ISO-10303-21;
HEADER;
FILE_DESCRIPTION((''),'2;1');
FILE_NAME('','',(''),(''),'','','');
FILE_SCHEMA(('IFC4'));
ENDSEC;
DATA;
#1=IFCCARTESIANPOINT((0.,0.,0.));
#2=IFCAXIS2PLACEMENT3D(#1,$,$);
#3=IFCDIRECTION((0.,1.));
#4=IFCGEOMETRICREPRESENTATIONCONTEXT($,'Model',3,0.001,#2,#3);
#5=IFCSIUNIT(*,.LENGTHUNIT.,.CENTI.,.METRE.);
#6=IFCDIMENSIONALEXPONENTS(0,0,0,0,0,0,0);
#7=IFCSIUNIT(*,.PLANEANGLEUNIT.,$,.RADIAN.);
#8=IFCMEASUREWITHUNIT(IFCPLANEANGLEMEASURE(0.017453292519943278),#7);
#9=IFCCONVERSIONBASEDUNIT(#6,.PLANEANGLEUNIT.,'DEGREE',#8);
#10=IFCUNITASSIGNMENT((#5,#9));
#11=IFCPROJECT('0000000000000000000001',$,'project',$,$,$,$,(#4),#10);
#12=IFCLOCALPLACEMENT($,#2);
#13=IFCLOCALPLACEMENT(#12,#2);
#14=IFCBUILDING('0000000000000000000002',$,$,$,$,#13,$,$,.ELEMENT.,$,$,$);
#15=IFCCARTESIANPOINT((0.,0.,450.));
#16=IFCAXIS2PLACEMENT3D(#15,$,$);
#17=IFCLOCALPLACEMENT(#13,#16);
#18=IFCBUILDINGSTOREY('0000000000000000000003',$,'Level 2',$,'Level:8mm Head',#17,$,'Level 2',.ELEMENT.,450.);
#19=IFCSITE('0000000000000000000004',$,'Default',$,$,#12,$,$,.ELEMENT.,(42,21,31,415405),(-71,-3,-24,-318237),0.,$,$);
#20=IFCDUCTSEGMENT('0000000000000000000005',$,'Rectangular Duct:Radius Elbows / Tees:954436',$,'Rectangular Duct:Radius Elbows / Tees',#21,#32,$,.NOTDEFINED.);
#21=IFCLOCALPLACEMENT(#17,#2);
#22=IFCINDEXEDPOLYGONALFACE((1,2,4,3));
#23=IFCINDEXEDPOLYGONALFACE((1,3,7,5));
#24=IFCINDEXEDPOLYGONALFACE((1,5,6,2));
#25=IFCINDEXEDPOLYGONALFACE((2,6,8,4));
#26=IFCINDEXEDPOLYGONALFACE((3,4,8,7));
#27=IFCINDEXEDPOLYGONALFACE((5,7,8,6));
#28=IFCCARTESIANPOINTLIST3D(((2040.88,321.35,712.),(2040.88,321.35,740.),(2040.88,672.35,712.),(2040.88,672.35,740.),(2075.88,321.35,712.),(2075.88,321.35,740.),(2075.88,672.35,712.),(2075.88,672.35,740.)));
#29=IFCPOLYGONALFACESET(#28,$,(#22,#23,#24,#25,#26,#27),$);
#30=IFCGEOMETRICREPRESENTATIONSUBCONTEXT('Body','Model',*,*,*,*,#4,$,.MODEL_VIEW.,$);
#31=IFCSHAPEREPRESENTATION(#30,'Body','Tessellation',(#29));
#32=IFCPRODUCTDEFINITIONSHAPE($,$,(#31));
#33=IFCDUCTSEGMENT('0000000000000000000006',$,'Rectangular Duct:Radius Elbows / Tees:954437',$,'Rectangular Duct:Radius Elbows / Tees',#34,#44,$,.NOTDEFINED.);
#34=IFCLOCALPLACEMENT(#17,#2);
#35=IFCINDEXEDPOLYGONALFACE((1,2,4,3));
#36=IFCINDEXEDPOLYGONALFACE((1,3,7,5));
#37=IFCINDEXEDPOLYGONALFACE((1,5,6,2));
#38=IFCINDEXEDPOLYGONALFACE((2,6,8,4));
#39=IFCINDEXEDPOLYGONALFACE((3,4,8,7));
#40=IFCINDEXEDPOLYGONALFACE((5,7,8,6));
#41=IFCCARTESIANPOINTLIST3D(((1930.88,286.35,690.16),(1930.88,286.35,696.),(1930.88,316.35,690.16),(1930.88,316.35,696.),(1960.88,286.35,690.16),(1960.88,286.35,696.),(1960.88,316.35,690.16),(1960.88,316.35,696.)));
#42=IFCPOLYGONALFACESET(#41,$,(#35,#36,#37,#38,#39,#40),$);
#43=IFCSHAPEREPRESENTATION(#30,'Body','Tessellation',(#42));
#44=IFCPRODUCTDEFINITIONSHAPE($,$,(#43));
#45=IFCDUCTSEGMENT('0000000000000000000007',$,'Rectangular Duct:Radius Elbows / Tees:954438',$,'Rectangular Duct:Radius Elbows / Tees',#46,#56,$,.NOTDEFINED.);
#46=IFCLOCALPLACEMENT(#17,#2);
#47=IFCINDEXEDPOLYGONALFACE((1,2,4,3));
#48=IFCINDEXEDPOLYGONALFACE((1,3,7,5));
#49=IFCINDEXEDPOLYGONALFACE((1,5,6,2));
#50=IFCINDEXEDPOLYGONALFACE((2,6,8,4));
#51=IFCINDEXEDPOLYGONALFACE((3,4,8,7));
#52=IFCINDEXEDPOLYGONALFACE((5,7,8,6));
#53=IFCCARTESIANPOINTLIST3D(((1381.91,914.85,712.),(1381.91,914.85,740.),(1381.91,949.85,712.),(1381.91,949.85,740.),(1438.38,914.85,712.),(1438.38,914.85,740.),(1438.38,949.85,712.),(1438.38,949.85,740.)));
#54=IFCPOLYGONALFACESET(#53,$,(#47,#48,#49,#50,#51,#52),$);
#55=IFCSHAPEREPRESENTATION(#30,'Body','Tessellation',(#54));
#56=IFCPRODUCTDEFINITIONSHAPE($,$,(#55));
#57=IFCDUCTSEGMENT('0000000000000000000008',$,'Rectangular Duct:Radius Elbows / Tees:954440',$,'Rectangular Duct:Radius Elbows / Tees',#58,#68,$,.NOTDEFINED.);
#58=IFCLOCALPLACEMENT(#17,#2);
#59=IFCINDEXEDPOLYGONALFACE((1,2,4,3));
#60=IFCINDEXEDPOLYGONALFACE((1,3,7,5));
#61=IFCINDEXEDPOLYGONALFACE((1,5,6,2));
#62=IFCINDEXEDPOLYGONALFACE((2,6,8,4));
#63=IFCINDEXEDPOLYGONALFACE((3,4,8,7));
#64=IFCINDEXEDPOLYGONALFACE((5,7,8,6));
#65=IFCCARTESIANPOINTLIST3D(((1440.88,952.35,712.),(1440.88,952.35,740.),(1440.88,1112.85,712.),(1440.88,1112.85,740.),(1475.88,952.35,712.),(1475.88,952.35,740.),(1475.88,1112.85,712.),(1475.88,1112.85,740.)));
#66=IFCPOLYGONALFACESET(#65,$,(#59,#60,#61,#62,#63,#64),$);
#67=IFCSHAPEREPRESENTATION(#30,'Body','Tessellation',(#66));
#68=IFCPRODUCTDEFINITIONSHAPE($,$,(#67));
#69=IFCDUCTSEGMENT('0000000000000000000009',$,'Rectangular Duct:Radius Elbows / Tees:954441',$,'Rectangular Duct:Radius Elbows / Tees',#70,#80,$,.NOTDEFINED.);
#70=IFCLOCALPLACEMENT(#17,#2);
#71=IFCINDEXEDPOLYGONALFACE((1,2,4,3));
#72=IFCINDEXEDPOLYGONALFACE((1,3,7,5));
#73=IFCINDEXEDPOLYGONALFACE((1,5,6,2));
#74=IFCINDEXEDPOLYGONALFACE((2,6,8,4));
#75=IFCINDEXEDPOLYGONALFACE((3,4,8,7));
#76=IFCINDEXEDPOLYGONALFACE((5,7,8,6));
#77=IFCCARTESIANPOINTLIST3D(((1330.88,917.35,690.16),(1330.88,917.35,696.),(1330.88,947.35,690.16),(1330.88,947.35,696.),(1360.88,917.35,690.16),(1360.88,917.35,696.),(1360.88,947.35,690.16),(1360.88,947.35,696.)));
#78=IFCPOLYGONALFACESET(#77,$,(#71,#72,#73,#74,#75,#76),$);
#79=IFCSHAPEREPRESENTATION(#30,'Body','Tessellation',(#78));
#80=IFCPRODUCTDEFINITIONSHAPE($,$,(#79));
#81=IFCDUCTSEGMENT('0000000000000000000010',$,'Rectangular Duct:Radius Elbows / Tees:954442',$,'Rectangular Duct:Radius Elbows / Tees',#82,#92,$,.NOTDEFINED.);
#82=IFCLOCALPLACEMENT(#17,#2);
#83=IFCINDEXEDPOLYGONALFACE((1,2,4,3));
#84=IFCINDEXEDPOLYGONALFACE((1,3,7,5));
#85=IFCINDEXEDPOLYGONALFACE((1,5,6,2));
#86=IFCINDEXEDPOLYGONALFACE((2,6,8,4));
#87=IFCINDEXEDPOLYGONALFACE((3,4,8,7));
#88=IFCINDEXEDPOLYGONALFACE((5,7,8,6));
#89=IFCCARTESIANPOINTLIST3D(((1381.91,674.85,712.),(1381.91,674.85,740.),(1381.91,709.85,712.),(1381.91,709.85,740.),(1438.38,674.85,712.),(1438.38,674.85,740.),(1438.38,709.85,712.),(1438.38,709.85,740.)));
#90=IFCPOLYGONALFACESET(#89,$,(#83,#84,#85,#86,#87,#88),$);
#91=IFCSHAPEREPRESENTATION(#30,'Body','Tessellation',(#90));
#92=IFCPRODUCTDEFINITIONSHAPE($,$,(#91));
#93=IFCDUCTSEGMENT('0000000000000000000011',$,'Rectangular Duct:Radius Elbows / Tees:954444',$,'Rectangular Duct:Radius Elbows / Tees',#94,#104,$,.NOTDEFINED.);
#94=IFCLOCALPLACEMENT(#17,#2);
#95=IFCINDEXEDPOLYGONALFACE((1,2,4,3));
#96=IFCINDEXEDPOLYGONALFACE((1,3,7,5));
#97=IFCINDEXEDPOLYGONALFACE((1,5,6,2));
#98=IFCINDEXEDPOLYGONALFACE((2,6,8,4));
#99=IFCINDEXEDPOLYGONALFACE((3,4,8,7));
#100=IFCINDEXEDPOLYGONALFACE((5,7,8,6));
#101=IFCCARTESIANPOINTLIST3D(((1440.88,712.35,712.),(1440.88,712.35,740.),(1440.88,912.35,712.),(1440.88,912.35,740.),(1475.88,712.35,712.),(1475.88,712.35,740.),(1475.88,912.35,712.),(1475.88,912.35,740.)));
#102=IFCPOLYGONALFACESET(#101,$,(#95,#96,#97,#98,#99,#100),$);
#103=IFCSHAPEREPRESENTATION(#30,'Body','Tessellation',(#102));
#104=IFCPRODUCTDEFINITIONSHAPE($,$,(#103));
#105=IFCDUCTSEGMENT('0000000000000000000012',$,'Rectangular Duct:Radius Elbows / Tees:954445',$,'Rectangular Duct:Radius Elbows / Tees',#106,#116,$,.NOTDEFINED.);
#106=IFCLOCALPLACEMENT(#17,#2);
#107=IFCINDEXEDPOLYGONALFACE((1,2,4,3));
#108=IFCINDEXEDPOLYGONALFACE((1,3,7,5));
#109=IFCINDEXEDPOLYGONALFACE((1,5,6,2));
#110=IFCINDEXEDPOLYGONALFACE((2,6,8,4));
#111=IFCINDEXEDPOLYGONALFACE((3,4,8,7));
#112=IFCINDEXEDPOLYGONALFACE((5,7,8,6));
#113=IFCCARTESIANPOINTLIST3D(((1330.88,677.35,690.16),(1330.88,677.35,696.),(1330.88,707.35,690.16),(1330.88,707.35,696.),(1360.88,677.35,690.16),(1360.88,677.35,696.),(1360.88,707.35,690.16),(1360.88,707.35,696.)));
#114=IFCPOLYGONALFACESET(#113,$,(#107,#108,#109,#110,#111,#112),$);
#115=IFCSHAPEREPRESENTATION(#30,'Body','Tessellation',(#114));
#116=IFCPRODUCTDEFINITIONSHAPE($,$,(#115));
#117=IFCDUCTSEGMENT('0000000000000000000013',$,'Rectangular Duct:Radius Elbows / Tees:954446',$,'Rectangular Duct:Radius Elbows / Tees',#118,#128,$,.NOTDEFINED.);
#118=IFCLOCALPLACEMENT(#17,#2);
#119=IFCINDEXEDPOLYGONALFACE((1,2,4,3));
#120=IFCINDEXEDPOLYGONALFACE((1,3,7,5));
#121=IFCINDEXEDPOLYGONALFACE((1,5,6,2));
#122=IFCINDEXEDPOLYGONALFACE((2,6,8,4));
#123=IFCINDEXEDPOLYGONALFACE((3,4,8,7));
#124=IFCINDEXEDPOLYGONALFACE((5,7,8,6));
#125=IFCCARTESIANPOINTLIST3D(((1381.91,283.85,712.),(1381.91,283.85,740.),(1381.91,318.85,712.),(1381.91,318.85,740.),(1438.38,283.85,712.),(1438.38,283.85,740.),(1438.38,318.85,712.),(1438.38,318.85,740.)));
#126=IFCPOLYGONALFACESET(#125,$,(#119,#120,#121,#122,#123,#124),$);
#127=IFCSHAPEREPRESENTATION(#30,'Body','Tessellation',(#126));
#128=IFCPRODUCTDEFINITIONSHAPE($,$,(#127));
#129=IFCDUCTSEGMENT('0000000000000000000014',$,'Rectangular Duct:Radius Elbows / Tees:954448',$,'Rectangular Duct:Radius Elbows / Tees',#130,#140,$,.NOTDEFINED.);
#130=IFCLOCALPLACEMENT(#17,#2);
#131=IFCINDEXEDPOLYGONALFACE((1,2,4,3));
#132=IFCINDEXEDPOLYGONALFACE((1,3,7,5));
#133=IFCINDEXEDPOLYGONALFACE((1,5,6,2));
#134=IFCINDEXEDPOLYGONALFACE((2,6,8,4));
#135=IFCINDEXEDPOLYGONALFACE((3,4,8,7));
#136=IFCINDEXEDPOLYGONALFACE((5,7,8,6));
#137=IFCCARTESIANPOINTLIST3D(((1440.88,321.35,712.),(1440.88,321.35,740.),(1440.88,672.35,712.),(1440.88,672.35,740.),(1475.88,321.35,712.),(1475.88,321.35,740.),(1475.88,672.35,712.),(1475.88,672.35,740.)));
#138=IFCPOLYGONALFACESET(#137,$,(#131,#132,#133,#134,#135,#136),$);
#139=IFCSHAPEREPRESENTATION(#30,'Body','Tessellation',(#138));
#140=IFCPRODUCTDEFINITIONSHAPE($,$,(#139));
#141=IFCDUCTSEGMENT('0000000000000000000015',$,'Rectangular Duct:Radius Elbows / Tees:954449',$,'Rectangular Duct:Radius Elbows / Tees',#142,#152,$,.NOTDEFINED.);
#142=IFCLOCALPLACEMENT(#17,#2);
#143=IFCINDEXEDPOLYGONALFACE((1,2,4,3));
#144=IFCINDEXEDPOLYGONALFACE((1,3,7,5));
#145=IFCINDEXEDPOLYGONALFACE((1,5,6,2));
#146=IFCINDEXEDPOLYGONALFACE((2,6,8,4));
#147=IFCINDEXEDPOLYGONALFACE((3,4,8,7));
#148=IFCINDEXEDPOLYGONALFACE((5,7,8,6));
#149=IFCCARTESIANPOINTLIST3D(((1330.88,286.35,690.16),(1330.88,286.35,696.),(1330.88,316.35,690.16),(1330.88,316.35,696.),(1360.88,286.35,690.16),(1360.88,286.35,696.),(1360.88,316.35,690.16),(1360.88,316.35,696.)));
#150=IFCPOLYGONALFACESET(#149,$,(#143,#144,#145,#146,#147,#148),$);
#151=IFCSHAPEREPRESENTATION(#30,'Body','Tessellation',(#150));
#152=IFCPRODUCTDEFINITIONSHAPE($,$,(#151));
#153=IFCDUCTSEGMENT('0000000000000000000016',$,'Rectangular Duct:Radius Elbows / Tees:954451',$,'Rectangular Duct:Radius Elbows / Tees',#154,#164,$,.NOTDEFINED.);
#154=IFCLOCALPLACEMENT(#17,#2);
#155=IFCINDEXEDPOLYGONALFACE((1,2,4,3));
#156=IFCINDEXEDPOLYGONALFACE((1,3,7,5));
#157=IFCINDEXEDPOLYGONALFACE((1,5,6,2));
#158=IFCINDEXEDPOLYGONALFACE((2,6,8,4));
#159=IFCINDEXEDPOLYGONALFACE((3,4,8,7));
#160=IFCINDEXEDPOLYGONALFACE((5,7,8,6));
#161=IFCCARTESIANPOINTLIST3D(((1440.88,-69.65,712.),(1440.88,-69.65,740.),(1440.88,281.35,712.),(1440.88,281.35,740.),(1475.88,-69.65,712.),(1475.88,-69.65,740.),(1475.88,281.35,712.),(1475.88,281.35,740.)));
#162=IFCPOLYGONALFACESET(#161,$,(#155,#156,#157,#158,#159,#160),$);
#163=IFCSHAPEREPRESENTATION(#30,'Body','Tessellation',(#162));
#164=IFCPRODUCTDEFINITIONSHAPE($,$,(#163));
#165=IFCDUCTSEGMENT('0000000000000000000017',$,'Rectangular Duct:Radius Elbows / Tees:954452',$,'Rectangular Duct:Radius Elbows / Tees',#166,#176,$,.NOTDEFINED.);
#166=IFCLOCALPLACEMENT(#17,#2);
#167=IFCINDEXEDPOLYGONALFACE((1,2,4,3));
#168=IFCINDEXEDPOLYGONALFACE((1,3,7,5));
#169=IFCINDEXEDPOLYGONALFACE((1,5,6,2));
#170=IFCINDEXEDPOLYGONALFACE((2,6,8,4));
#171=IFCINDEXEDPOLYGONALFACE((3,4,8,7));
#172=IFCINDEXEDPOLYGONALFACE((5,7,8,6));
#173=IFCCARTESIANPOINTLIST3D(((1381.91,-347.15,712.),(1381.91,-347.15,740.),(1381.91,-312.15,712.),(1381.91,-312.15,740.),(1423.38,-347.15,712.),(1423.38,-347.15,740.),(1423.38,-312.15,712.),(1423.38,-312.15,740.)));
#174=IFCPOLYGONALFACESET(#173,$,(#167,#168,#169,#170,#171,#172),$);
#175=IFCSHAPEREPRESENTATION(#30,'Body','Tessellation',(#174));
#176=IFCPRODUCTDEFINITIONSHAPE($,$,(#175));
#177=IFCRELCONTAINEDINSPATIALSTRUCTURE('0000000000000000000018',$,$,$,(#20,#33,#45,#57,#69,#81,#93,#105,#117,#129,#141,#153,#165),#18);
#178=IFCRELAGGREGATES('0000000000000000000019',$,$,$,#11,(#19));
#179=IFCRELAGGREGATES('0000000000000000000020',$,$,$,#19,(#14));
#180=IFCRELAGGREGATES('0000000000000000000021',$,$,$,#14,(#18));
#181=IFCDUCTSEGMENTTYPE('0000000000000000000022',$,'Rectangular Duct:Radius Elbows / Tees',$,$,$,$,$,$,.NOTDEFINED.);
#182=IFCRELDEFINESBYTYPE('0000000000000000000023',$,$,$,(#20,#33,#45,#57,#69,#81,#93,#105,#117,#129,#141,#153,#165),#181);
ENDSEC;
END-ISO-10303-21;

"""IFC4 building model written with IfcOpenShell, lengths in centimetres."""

from ifc_helpers import new_model, entity, si_unit, converted_unit, direction, frame, origin, place, context, subcontext, project, spatial, indexed_curve, outline, extrude, type_object, element, save


model = new_model("IFC4")

# Units and contexts
model_context = context("Model", 3, precision=0.001, world=origin(), true_north=direction((0.0, 1.0)))
body_context = subcontext(model_context, "Body", "Model", "MODEL_VIEW")
ifc_project = project(units=[si_unit("LENGTHUNIT", "METRE", prefix="CENTI"), converted_unit("PLANEANGLEUNIT", "DEGREE", entity("IfcPlaneAngleMeasure", 0.017453292519943278), si_unit("PLANEANGLEUNIT", "RADIAN"), dimensions=[0, 0, 0, 0, 0, 0, 0])], contexts=[model_context])

# Site, building, storey
site_placement = place(None, origin())
site = spatial("IfcSite", under=ifc_project, at=site_placement, Name="Default", CompositionType="ELEMENT", RefLatitude=(42, 21, 31, 415405), RefLongitude=(-71, -3, -24, -318237), RefElevation=0.0)
building_placement = place(site_placement, origin())
building = spatial("IfcBuilding", under=site, at=building_placement, CompositionType="ELEMENT")
storey_placement = place(building_placement, frame((0.0, 0.0, 450.0)))
storey = spatial("IfcBuildingStorey", under=building, at=storey_placement, Name="Level 2", ObjectType="Level:8mm Head", LongName="Level 2", CompositionType="ELEMENT", Elevation=450.0)

# Duct segments
duct_segment_type = type_object("IfcDuctSegmentType", Name="Rectangular Duct:Radius Elbows / Tees", PredefinedType="NOTDEFINED")
duct_segment_1_placement = place(storey_placement, origin())
element("IfcDuctSegment", 1, at=duct_segment_1_placement, inside=storey, type_object=duct_segment_type, Name="Rectangular Duct:Radius Elbows / Tees:954436", ObjectType="Rectangular Duct:Radius Elbows / Tees", PredefinedType="NOTDEFINED", context=body_context, shape_type="SweptSolid", body=[
    extrude(outline(indexed_curve([(-175.5, -17.5), (175.5, -17.5), (175.5, 17.5), (-175.5, 17.5), (-175.5, -17.5)], self_intersect=False)), frame((2058.38, 496.85, 712.0), z_axis=(0.0, 0.0, 1.0), x_axis=(0.0, -1.0, 0.0)), (0.0, 0.0, 1.0), 28.0),
])
duct_segment_2_placement = place(storey_placement, origin())
element("IfcDuctSegment", 2, at=duct_segment_2_placement, inside=storey, type_object=duct_segment_type, Name="Rectangular Duct:Radius Elbows / Tees:954437", ObjectType="Rectangular Duct:Radius Elbows / Tees", PredefinedType="NOTDEFINED", context=body_context, shape_type="SweptSolid", body=[
    extrude(outline(indexed_curve([(-15.0, -15.0), (15.0, -15.0), (15.0, 15.0), (-15.0, 15.0), (-15.0, -15.0)], self_intersect=False)), frame((1945.88, 301.35, 690.16)), (0.0, 0.0, 1.0), 5.84),
])
duct_segment_3_placement = place(storey_placement, origin())
element("IfcDuctSegment", 3, at=duct_segment_3_placement, inside=storey, type_object=duct_segment_type, Name="Rectangular Duct:Radius Elbows / Tees:954438", ObjectType="Rectangular Duct:Radius Elbows / Tees", PredefinedType="NOTDEFINED", context=body_context, shape_type="SweptSolid", body=[
    extrude(outline(indexed_curve([(-28.23, -17.5), (28.23, -17.5), (28.23, 17.5), (-28.23, 17.5), (-28.23, -17.5)], self_intersect=False)), frame((1410.14, 932.35, 712.0)), (0.0, 0.0, 1.0), 28.0),
])
duct_segment_4_placement = place(storey_placement, origin())
element("IfcDuctSegment", 4, at=duct_segment_4_placement, inside=storey, type_object=duct_segment_type, Name="Rectangular Duct:Radius Elbows / Tees:954440", ObjectType="Rectangular Duct:Radius Elbows / Tees", PredefinedType="NOTDEFINED", context=body_context, shape_type="SweptSolid", body=[
    extrude(outline(indexed_curve([(-80.25, -17.5), (80.25, -17.5), (80.25, 17.5), (-80.25, 17.5), (-80.25, -17.5)], self_intersect=False)), frame((1458.38, 1032.6, 712.0), z_axis=(0.0, 0.0, 1.0), x_axis=(0.0, -1.0, 0.0)), (0.0, 0.0, 1.0), 28.0),
])
duct_segment_5_placement = place(storey_placement, origin())
element("IfcDuctSegment", 5, at=duct_segment_5_placement, inside=storey, type_object=duct_segment_type, Name="Rectangular Duct:Radius Elbows / Tees:954441", ObjectType="Rectangular Duct:Radius Elbows / Tees", PredefinedType="NOTDEFINED", context=body_context, shape_type="SweptSolid", body=[
    extrude(outline(indexed_curve([(-15.0, -15.0), (15.0, -15.0), (15.0, 15.0), (-15.0, 15.0), (-15.0, -15.0)], self_intersect=False)), frame((1345.88, 932.35, 690.16)), (0.0, 0.0, 1.0), 5.84),
])
duct_segment_6_placement = place(storey_placement, origin())
element("IfcDuctSegment", 6, at=duct_segment_6_placement, inside=storey, type_object=duct_segment_type, Name="Rectangular Duct:Radius Elbows / Tees:954442", ObjectType="Rectangular Duct:Radius Elbows / Tees", PredefinedType="NOTDEFINED", context=body_context, shape_type="SweptSolid", body=[
    extrude(outline(indexed_curve([(-28.23, -17.5), (28.23, -17.5), (28.23, 17.5), (-28.23, 17.5), (-28.23, -17.5)], self_intersect=False)), frame((1410.14, 692.35, 712.0)), (0.0, 0.0, 1.0), 28.0),
])
duct_segment_7_placement = place(storey_placement, origin())
element("IfcDuctSegment", 7, at=duct_segment_7_placement, inside=storey, type_object=duct_segment_type, Name="Rectangular Duct:Radius Elbows / Tees:954444", ObjectType="Rectangular Duct:Radius Elbows / Tees", PredefinedType="NOTDEFINED", context=body_context, shape_type="SweptSolid", body=[
    extrude(outline(indexed_curve([(-100.0, -17.5), (100.0, -17.5), (100.0, 17.5), (-100.0, 17.5), (-100.0, -17.5)], self_intersect=False)), frame((1458.38, 812.35, 712.0), z_axis=(0.0, 0.0, 1.0), x_axis=(0.0, -1.0, 0.0)), (0.0, 0.0, 1.0), 28.0),
])
duct_segment_8_placement = place(storey_placement, origin())
element("IfcDuctSegment", 8, at=duct_segment_8_placement, inside=storey, type_object=duct_segment_type, Name="Rectangular Duct:Radius Elbows / Tees:954445", ObjectType="Rectangular Duct:Radius Elbows / Tees", PredefinedType="NOTDEFINED", context=body_context, shape_type="SweptSolid", body=[
    extrude(outline(indexed_curve([(-15.0, -15.0), (15.0, -15.0), (15.0, 15.0), (-15.0, 15.0), (-15.0, -15.0)], self_intersect=False)), frame((1345.88, 692.35, 690.16)), (0.0, 0.0, 1.0), 5.84),
])
duct_segment_9_placement = place(storey_placement, origin())
element("IfcDuctSegment", 9, at=duct_segment_9_placement, inside=storey, type_object=duct_segment_type, Name="Rectangular Duct:Radius Elbows / Tees:954446", ObjectType="Rectangular Duct:Radius Elbows / Tees", PredefinedType="NOTDEFINED", context=body_context, shape_type="SweptSolid", body=[
    extrude(outline(indexed_curve([(-28.23, -17.5), (28.23, -17.5), (28.23, 17.5), (-28.23, 17.5), (-28.23, -17.5)], self_intersect=False)), frame((1410.14, 301.35, 712.0), z_axis=(0.0, 0.0, 1.0), x_axis=(-1.0, 0.0, 0.0)), (0.0, 0.0, 1.0), 28.0),
])
duct_segment_10_placement = place(storey_placement, origin())
element("IfcDuctSegment", 10, at=duct_segment_10_placement, inside=storey, type_object=duct_segment_type, Name="Rectangular Duct:Radius Elbows / Tees:954448", ObjectType="Rectangular Duct:Radius Elbows / Tees", PredefinedType="NOTDEFINED", context=body_context, shape_type="SweptSolid", body=[
    extrude(outline(indexed_curve([(-175.5, -17.5), (175.5, -17.5), (175.5, 17.5), (-175.5, 17.5), (-175.5, -17.5)], self_intersect=False)), frame((1458.38, 496.85, 712.0), z_axis=(0.0, 0.0, 1.0), x_axis=(0.0, -1.0, 0.0)), (0.0, 0.0, 1.0), 28.0),
])
duct_segment_11_placement = place(storey_placement, origin())
element("IfcDuctSegment", 11, at=duct_segment_11_placement, inside=storey, type_object=duct_segment_type, Name="Rectangular Duct:Radius Elbows / Tees:954449", ObjectType="Rectangular Duct:Radius Elbows / Tees", PredefinedType="NOTDEFINED", context=body_context, shape_type="SweptSolid", body=[
    extrude(outline(indexed_curve([(-15.0, -15.0), (15.0, -15.0), (15.0, 15.0), (-15.0, 15.0), (-15.0, -15.0)], self_intersect=False)), frame((1345.88, 301.35, 690.16)), (0.0, 0.0, 1.0), 5.84),
])
duct_segment_12_placement = place(storey_placement, origin())
element("IfcDuctSegment", 12, at=duct_segment_12_placement, inside=storey, type_object=duct_segment_type, Name="Rectangular Duct:Radius Elbows / Tees:954451", ObjectType="Rectangular Duct:Radius Elbows / Tees", PredefinedType="NOTDEFINED", context=body_context, shape_type="SweptSolid", body=[
    extrude(outline(indexed_curve([(-175.5, -17.5), (175.5, -17.5), (175.5, 17.5), (-175.5, 17.5), (-175.5, -17.5)], self_intersect=False)), frame((1458.38, 105.85, 712.0), z_axis=(0.0, 0.0, 1.0), x_axis=(0.0, -1.0, 0.0)), (0.0, 0.0, 1.0), 28.0),
])
duct_segment_13_placement = place(storey_placement, origin())
element("IfcDuctSegment", 13, at=duct_segment_13_placement, inside=storey, type_object=duct_segment_type, Name="Rectangular Duct:Radius Elbows / Tees:954452", ObjectType="Rectangular Duct:Radius Elbows / Tees", PredefinedType="NOTDEFINED", context=body_context, shape_type="SweptSolid", body=[
    extrude(outline(indexed_curve([(-20.73, -17.5), (20.73, -17.5), (20.73, 17.5), (-20.73, 17.5), (-20.73, -17.5)], self_intersect=False)), frame((1402.64, -329.65, 712.0), z_axis=(0.0, 0.0, 1.0), x_axis=(-1.0, 0.0, 0.0)), (0.0, 0.0, 1.0), 28.0),
])

save(model, "model.ifc")
